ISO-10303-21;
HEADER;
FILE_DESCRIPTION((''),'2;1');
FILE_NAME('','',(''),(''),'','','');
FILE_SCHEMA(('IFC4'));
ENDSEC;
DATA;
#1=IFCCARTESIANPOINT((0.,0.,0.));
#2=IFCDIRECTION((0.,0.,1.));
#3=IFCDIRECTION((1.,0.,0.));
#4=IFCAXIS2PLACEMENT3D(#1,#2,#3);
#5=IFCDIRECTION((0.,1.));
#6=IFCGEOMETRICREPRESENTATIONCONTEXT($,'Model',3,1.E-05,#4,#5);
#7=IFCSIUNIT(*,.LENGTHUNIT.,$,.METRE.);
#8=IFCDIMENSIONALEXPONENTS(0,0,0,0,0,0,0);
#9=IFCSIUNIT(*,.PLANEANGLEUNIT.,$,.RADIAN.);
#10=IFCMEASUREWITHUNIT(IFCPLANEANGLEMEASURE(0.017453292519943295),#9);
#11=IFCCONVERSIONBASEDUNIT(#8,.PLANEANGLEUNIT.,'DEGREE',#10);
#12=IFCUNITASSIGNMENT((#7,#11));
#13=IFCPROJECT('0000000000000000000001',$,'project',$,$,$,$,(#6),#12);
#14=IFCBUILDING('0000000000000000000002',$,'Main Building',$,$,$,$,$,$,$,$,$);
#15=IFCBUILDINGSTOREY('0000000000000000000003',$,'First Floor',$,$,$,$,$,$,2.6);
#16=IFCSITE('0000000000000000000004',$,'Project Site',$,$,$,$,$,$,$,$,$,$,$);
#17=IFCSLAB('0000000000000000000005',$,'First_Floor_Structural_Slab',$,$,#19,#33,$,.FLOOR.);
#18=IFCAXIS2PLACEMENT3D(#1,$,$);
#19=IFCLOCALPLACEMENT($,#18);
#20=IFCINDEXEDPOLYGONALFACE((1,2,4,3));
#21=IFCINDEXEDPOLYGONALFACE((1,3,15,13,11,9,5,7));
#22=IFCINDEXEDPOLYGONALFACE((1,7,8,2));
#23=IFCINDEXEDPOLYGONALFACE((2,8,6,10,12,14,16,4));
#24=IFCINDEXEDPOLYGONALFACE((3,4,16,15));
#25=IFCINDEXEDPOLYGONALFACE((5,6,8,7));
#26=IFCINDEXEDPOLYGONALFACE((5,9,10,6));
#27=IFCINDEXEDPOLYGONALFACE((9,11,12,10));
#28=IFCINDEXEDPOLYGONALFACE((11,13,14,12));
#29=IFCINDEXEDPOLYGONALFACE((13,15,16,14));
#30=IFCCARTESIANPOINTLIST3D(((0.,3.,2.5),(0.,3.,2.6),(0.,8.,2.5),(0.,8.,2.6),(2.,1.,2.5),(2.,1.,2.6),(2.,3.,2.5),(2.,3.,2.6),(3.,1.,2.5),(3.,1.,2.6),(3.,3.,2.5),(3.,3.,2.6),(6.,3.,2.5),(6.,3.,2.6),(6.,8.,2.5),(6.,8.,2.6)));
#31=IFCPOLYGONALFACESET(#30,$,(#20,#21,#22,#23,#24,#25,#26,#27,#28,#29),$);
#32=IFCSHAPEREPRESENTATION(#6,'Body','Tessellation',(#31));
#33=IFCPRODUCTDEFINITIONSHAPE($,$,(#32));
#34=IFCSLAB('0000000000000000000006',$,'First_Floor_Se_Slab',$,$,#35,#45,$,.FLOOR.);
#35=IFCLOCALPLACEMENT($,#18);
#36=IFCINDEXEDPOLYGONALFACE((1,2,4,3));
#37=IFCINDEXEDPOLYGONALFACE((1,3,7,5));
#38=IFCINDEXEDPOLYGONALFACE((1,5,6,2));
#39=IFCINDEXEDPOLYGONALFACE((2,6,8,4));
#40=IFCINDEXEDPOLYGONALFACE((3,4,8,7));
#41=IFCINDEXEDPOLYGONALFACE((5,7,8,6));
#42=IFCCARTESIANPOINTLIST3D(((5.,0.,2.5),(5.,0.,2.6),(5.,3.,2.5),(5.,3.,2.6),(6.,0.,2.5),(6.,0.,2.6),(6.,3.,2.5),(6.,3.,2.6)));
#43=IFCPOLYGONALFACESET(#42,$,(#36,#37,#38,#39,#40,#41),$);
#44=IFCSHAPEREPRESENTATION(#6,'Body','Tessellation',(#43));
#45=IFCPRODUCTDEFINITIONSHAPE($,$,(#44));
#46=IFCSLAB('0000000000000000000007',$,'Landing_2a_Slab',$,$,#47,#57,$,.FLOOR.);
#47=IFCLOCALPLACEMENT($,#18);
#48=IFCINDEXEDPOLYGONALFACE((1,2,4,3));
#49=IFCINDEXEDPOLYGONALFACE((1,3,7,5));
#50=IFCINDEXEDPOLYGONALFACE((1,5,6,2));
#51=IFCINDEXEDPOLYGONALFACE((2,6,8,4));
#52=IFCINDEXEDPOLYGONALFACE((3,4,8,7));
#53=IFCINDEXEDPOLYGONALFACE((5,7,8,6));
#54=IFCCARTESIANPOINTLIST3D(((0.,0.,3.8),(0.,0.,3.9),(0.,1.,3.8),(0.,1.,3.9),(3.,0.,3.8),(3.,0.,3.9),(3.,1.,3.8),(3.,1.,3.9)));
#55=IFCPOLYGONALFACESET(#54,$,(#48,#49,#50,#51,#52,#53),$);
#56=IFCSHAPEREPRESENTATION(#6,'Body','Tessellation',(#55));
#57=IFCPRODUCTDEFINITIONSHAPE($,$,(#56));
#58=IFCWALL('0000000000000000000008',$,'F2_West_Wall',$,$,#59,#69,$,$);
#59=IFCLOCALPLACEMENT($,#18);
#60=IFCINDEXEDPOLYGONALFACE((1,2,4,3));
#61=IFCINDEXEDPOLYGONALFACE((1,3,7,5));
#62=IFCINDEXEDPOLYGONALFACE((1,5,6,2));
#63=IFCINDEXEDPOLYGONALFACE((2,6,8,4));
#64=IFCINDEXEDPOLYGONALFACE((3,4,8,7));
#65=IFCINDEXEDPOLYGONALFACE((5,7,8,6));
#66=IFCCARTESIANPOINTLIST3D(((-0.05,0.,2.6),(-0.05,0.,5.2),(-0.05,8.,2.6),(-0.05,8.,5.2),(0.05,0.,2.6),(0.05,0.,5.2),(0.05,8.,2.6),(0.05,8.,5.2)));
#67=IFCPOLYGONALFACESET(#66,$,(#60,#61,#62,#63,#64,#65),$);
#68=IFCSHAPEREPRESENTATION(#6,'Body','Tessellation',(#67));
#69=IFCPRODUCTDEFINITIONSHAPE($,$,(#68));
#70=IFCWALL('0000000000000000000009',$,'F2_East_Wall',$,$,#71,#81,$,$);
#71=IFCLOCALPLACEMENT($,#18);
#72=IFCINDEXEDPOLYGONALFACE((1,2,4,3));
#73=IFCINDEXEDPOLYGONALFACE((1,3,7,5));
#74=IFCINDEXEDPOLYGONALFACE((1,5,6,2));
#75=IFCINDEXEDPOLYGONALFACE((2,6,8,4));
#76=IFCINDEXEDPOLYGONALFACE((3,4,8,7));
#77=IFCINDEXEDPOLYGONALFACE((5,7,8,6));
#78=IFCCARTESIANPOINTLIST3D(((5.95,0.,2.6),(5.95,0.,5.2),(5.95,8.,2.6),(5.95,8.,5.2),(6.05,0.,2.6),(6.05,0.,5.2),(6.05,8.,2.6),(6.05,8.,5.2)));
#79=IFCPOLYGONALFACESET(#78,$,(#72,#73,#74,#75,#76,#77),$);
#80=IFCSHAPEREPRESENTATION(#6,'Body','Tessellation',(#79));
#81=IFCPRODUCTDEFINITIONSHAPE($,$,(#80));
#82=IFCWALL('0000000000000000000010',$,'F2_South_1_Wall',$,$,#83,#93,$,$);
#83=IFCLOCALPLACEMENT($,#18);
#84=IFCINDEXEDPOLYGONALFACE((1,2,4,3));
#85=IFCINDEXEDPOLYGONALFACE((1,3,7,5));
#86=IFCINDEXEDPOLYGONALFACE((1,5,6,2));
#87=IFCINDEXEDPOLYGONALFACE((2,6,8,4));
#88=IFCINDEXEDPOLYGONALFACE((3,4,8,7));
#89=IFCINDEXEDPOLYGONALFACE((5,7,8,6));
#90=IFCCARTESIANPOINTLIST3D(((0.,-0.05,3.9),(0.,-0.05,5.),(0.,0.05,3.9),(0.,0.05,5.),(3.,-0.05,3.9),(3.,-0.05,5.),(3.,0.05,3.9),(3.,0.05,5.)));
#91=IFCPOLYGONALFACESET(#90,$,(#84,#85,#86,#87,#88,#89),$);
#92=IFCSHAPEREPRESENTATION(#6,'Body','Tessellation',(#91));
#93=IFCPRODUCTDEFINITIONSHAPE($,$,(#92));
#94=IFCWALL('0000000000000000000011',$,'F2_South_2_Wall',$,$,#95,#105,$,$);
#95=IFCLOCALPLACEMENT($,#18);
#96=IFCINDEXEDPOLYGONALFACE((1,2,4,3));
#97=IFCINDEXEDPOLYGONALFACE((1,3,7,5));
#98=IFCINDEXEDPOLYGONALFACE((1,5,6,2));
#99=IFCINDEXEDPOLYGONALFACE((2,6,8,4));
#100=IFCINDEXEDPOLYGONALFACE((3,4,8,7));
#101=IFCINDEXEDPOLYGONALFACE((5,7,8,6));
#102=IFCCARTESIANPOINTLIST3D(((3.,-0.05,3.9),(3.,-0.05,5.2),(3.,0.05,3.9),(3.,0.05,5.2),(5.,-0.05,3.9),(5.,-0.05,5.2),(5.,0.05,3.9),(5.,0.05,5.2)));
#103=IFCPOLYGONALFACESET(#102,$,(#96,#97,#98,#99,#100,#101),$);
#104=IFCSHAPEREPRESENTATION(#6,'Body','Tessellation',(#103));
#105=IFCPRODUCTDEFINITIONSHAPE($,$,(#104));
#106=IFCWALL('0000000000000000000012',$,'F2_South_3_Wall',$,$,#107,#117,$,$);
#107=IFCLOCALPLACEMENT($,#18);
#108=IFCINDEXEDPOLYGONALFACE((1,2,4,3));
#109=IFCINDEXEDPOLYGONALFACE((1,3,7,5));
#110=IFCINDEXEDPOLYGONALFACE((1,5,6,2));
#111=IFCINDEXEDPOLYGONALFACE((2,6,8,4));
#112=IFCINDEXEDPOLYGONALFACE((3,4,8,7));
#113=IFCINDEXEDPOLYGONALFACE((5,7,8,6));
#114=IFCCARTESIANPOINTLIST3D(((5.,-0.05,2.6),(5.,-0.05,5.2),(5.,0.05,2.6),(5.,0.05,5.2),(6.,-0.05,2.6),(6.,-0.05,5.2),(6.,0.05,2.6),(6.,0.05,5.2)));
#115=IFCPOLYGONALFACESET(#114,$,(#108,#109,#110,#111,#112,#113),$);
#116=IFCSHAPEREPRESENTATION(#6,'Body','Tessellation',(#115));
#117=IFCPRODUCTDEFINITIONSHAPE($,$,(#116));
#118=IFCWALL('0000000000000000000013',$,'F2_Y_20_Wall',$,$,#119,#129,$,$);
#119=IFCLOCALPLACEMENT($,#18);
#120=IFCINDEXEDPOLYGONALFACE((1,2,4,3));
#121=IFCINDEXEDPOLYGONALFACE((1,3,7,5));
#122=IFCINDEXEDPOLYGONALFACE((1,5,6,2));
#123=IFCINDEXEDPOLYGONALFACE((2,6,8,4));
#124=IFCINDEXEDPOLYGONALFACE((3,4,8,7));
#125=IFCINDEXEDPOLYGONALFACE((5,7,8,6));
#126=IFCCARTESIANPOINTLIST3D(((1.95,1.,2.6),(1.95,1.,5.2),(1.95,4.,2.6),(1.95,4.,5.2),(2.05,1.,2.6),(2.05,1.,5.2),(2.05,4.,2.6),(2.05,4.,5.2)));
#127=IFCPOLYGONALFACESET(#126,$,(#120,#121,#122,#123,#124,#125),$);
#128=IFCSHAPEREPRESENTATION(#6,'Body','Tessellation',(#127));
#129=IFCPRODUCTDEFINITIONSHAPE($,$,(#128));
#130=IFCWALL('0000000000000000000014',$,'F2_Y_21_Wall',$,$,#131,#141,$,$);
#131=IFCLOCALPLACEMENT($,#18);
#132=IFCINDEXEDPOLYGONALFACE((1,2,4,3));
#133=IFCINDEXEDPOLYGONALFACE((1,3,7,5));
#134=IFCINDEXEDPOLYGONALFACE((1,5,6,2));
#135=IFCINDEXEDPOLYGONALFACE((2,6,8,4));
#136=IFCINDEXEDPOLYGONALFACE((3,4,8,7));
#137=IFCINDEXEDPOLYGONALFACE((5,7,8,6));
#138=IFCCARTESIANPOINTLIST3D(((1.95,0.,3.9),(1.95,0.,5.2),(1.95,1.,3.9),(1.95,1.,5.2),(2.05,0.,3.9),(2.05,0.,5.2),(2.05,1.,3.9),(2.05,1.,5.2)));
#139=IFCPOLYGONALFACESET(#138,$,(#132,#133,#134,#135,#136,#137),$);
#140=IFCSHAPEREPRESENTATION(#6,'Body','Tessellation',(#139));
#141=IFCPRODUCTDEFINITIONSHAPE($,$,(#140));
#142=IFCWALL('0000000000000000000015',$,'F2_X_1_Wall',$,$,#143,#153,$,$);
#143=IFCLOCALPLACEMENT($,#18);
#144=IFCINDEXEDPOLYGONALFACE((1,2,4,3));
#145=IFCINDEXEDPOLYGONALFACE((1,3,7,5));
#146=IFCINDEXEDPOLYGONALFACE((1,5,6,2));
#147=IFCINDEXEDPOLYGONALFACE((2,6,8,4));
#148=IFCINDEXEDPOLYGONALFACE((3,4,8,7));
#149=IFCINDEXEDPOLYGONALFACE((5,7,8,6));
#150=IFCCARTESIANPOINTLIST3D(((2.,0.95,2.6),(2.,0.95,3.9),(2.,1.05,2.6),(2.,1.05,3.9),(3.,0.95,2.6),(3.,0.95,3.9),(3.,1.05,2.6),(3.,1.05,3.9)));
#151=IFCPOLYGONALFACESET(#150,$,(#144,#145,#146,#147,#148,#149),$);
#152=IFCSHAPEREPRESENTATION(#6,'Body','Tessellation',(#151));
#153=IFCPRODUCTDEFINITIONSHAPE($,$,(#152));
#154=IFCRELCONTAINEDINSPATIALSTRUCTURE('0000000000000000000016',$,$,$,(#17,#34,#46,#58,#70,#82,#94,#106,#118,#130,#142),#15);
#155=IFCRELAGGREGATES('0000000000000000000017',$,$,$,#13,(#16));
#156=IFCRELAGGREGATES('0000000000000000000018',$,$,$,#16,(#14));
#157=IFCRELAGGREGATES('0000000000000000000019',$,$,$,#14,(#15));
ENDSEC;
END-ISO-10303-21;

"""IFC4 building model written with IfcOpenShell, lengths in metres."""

from ifc_helpers import new_model, entity, si_unit, converted_unit, direction, frame, frame_2d, origin, origin_with_axes, place, context, project, spatial, polyline, rectangle, outline, extrude, element, save


model = new_model("IFC4")

# Units and contexts
model_context = context("Model", 3, precision=1e-05, world=origin_with_axes(), true_north=direction((0.0, 1.0)))
ifc_project = project(units=[si_unit("LENGTHUNIT", "METRE"), converted_unit("PLANEANGLEUNIT", "DEGREE", entity("IfcPlaneAngleMeasure", 0.017453292519943295), si_unit("PLANEANGLEUNIT", "RADIAN"), dimensions=[0, 0, 0, 0, 0, 0, 0])], contexts=[model_context])

# Site, building, storey
site = spatial("IfcSite", under=ifc_project, Name="Project Site")
building = spatial("IfcBuilding", under=site, Name="Main Building")
storey = spatial("IfcBuildingStorey", under=building, Name="First Floor", Elevation=2.6)

# Slabs
slab_1_placement = place(None, frame((0.0, 0.0, 2.5), z_axis=(0.0, 0.0, 1.0), x_axis=(1.0, 0.0, 0.0)))
element("IfcSlab", 1, at=slab_1_placement, inside=storey, Name="First_Floor_Structural_Slab", PredefinedType="FLOOR", context=model_context, shape_type="SweptSolid", body=[
    extrude(outline(polyline([(0.0, 3.0), (2.0, 3.0), (2.0, 1.0), (3.0, 1.0), (3.0, 3.0), (6.0, 3.0), (6.0, 8.0), (0.0, 8.0), (0.0, 3.0)])), origin(), (0.0, 0.0, 1.0), 0.1),
])
slab_2_placement = place(None, frame((0.0, 0.0, 2.5), z_axis=(0.0, 0.0, 1.0), x_axis=(1.0, 0.0, 0.0)))
element("IfcSlab", 2, at=slab_2_placement, inside=storey, Name="First_Floor_Se_Slab", PredefinedType="FLOOR", context=model_context, shape_type="SweptSolid", body=[
    extrude(outline(polyline([(5.0, 0.0), (6.0, 0.0), (6.0, 3.0), (5.0, 3.0), (5.0, 0.0)])), origin(), (0.0, 0.0, 1.0), 0.1),
])
slab_3_placement = place(None, frame((0.0, 0.0, 3.8), z_axis=(0.0, 0.0, 1.0), x_axis=(1.0, 0.0, 0.0)))
element("IfcSlab", 3, at=slab_3_placement, inside=storey, Name="Landing_2a_Slab", PredefinedType="FLOOR", context=model_context, shape_type="SweptSolid", body=[
    extrude(outline(polyline([(0.0, 0.0), (3.0, 0.0), (3.0, 1.0), (0.0, 1.0), (0.0, 0.0)])), origin(), (0.0, 0.0, 1.0), 0.1),
])

# Walls
for number, where, z_axis, x_axis, name in (
    (4, (0.0, 0.0, 2.6), (0.0, 0.0, 1.0), (0.0, 1.0, 0.0), "F2_West_Wall"),
    (5, (6.0, 0.0, 2.6), (0.0, 0.0, 1.0), (0.0, 1.0, 0.0), "F2_East_Wall"),
):
    element("IfcWall", number, at=place(None, frame(where, z_axis=z_axis, x_axis=x_axis)), inside=storey, Name=name, context=model_context, shape_type="SweptSolid", body=[
        extrude(rectangle(XDim=8.0, YDim=0.1, at=frame_2d((4.0, 0.0))), origin(), (0.0, 0.0, 1.0), 2.6),
    ])
wall_1_placement = place(None, frame((0.0, 0.0, 3.9), z_axis=(0.0, 0.0, 1.0), x_axis=(1.0, 0.0, 0.0)))
element("IfcWall", 6, at=wall_1_placement, inside=storey, Name="F2_South_1_Wall", context=model_context, shape_type="SweptSolid", body=[
    extrude(rectangle(XDim=3.0, YDim=0.1, at=frame_2d((1.5, 0.0))), origin(), (0.0, 0.0, 1.0), 1.1),
])
wall_2_placement = place(None, frame((3.0, 0.0, 3.9), z_axis=(0.0, 0.0, 1.0), x_axis=(1.0, 0.0, 0.0)))
element("IfcWall", 7, at=wall_2_placement, inside=storey, Name="F2_South_2_Wall", context=model_context, shape_type="SweptSolid", body=[
    extrude(rectangle(XDim=2.0, YDim=0.1, at=frame_2d((1.0, 0.0))), origin(), (0.0, 0.0, 1.0), 1.3),
])
wall_3_placement = place(None, frame((5.0, 0.0, 2.6), z_axis=(0.0, 0.0, 1.0), x_axis=(1.0, 0.0, 0.0)))
element("IfcWall", 8, at=wall_3_placement, inside=storey, Name="F2_South_3_Wall", context=model_context, shape_type="SweptSolid", body=[
    extrude(rectangle(XDim=1.0, YDim=0.1, at=frame_2d((0.5, 0.0))), origin(), (0.0, 0.0, 1.0), 2.6),
])
wall_4_placement = place(None, frame((2.0, 1.0, 2.6), z_axis=(0.0, 0.0, 1.0), x_axis=(0.0, 1.0, 0.0)))
element("IfcWall", 9, at=wall_4_placement, inside=storey, Name="F2_Y_20_Wall", context=model_context, shape_type="SweptSolid", body=[
    extrude(rectangle(XDim=3.0, YDim=0.1, at=frame_2d((1.5, 0.0))), origin(), (0.0, 0.0, 1.0), 2.6),
])
for number, where, z_axis, x_axis, name in (
    (10, (2.0, 0.0, 3.9), (0.0, 0.0, 1.0), (0.0, 1.0, 0.0), "F2_Y_21_Wall"),
    (11, (2.0, 1.0, 2.6), (0.0, 0.0, 1.0), (1.0, 0.0, 0.0), "F2_X_1_Wall"),
):
    element("IfcWall", number, at=place(None, frame(where, z_axis=z_axis, x_axis=x_axis)), inside=storey, Name=name, context=model_context, shape_type="SweptSolid", body=[
        extrude(rectangle(XDim=1.0, YDim=0.1, at=frame_2d((0.5, 0.0))), origin(), (0.0, 0.0, 1.0), 1.3),
    ])

save(model, "model.ifc")
